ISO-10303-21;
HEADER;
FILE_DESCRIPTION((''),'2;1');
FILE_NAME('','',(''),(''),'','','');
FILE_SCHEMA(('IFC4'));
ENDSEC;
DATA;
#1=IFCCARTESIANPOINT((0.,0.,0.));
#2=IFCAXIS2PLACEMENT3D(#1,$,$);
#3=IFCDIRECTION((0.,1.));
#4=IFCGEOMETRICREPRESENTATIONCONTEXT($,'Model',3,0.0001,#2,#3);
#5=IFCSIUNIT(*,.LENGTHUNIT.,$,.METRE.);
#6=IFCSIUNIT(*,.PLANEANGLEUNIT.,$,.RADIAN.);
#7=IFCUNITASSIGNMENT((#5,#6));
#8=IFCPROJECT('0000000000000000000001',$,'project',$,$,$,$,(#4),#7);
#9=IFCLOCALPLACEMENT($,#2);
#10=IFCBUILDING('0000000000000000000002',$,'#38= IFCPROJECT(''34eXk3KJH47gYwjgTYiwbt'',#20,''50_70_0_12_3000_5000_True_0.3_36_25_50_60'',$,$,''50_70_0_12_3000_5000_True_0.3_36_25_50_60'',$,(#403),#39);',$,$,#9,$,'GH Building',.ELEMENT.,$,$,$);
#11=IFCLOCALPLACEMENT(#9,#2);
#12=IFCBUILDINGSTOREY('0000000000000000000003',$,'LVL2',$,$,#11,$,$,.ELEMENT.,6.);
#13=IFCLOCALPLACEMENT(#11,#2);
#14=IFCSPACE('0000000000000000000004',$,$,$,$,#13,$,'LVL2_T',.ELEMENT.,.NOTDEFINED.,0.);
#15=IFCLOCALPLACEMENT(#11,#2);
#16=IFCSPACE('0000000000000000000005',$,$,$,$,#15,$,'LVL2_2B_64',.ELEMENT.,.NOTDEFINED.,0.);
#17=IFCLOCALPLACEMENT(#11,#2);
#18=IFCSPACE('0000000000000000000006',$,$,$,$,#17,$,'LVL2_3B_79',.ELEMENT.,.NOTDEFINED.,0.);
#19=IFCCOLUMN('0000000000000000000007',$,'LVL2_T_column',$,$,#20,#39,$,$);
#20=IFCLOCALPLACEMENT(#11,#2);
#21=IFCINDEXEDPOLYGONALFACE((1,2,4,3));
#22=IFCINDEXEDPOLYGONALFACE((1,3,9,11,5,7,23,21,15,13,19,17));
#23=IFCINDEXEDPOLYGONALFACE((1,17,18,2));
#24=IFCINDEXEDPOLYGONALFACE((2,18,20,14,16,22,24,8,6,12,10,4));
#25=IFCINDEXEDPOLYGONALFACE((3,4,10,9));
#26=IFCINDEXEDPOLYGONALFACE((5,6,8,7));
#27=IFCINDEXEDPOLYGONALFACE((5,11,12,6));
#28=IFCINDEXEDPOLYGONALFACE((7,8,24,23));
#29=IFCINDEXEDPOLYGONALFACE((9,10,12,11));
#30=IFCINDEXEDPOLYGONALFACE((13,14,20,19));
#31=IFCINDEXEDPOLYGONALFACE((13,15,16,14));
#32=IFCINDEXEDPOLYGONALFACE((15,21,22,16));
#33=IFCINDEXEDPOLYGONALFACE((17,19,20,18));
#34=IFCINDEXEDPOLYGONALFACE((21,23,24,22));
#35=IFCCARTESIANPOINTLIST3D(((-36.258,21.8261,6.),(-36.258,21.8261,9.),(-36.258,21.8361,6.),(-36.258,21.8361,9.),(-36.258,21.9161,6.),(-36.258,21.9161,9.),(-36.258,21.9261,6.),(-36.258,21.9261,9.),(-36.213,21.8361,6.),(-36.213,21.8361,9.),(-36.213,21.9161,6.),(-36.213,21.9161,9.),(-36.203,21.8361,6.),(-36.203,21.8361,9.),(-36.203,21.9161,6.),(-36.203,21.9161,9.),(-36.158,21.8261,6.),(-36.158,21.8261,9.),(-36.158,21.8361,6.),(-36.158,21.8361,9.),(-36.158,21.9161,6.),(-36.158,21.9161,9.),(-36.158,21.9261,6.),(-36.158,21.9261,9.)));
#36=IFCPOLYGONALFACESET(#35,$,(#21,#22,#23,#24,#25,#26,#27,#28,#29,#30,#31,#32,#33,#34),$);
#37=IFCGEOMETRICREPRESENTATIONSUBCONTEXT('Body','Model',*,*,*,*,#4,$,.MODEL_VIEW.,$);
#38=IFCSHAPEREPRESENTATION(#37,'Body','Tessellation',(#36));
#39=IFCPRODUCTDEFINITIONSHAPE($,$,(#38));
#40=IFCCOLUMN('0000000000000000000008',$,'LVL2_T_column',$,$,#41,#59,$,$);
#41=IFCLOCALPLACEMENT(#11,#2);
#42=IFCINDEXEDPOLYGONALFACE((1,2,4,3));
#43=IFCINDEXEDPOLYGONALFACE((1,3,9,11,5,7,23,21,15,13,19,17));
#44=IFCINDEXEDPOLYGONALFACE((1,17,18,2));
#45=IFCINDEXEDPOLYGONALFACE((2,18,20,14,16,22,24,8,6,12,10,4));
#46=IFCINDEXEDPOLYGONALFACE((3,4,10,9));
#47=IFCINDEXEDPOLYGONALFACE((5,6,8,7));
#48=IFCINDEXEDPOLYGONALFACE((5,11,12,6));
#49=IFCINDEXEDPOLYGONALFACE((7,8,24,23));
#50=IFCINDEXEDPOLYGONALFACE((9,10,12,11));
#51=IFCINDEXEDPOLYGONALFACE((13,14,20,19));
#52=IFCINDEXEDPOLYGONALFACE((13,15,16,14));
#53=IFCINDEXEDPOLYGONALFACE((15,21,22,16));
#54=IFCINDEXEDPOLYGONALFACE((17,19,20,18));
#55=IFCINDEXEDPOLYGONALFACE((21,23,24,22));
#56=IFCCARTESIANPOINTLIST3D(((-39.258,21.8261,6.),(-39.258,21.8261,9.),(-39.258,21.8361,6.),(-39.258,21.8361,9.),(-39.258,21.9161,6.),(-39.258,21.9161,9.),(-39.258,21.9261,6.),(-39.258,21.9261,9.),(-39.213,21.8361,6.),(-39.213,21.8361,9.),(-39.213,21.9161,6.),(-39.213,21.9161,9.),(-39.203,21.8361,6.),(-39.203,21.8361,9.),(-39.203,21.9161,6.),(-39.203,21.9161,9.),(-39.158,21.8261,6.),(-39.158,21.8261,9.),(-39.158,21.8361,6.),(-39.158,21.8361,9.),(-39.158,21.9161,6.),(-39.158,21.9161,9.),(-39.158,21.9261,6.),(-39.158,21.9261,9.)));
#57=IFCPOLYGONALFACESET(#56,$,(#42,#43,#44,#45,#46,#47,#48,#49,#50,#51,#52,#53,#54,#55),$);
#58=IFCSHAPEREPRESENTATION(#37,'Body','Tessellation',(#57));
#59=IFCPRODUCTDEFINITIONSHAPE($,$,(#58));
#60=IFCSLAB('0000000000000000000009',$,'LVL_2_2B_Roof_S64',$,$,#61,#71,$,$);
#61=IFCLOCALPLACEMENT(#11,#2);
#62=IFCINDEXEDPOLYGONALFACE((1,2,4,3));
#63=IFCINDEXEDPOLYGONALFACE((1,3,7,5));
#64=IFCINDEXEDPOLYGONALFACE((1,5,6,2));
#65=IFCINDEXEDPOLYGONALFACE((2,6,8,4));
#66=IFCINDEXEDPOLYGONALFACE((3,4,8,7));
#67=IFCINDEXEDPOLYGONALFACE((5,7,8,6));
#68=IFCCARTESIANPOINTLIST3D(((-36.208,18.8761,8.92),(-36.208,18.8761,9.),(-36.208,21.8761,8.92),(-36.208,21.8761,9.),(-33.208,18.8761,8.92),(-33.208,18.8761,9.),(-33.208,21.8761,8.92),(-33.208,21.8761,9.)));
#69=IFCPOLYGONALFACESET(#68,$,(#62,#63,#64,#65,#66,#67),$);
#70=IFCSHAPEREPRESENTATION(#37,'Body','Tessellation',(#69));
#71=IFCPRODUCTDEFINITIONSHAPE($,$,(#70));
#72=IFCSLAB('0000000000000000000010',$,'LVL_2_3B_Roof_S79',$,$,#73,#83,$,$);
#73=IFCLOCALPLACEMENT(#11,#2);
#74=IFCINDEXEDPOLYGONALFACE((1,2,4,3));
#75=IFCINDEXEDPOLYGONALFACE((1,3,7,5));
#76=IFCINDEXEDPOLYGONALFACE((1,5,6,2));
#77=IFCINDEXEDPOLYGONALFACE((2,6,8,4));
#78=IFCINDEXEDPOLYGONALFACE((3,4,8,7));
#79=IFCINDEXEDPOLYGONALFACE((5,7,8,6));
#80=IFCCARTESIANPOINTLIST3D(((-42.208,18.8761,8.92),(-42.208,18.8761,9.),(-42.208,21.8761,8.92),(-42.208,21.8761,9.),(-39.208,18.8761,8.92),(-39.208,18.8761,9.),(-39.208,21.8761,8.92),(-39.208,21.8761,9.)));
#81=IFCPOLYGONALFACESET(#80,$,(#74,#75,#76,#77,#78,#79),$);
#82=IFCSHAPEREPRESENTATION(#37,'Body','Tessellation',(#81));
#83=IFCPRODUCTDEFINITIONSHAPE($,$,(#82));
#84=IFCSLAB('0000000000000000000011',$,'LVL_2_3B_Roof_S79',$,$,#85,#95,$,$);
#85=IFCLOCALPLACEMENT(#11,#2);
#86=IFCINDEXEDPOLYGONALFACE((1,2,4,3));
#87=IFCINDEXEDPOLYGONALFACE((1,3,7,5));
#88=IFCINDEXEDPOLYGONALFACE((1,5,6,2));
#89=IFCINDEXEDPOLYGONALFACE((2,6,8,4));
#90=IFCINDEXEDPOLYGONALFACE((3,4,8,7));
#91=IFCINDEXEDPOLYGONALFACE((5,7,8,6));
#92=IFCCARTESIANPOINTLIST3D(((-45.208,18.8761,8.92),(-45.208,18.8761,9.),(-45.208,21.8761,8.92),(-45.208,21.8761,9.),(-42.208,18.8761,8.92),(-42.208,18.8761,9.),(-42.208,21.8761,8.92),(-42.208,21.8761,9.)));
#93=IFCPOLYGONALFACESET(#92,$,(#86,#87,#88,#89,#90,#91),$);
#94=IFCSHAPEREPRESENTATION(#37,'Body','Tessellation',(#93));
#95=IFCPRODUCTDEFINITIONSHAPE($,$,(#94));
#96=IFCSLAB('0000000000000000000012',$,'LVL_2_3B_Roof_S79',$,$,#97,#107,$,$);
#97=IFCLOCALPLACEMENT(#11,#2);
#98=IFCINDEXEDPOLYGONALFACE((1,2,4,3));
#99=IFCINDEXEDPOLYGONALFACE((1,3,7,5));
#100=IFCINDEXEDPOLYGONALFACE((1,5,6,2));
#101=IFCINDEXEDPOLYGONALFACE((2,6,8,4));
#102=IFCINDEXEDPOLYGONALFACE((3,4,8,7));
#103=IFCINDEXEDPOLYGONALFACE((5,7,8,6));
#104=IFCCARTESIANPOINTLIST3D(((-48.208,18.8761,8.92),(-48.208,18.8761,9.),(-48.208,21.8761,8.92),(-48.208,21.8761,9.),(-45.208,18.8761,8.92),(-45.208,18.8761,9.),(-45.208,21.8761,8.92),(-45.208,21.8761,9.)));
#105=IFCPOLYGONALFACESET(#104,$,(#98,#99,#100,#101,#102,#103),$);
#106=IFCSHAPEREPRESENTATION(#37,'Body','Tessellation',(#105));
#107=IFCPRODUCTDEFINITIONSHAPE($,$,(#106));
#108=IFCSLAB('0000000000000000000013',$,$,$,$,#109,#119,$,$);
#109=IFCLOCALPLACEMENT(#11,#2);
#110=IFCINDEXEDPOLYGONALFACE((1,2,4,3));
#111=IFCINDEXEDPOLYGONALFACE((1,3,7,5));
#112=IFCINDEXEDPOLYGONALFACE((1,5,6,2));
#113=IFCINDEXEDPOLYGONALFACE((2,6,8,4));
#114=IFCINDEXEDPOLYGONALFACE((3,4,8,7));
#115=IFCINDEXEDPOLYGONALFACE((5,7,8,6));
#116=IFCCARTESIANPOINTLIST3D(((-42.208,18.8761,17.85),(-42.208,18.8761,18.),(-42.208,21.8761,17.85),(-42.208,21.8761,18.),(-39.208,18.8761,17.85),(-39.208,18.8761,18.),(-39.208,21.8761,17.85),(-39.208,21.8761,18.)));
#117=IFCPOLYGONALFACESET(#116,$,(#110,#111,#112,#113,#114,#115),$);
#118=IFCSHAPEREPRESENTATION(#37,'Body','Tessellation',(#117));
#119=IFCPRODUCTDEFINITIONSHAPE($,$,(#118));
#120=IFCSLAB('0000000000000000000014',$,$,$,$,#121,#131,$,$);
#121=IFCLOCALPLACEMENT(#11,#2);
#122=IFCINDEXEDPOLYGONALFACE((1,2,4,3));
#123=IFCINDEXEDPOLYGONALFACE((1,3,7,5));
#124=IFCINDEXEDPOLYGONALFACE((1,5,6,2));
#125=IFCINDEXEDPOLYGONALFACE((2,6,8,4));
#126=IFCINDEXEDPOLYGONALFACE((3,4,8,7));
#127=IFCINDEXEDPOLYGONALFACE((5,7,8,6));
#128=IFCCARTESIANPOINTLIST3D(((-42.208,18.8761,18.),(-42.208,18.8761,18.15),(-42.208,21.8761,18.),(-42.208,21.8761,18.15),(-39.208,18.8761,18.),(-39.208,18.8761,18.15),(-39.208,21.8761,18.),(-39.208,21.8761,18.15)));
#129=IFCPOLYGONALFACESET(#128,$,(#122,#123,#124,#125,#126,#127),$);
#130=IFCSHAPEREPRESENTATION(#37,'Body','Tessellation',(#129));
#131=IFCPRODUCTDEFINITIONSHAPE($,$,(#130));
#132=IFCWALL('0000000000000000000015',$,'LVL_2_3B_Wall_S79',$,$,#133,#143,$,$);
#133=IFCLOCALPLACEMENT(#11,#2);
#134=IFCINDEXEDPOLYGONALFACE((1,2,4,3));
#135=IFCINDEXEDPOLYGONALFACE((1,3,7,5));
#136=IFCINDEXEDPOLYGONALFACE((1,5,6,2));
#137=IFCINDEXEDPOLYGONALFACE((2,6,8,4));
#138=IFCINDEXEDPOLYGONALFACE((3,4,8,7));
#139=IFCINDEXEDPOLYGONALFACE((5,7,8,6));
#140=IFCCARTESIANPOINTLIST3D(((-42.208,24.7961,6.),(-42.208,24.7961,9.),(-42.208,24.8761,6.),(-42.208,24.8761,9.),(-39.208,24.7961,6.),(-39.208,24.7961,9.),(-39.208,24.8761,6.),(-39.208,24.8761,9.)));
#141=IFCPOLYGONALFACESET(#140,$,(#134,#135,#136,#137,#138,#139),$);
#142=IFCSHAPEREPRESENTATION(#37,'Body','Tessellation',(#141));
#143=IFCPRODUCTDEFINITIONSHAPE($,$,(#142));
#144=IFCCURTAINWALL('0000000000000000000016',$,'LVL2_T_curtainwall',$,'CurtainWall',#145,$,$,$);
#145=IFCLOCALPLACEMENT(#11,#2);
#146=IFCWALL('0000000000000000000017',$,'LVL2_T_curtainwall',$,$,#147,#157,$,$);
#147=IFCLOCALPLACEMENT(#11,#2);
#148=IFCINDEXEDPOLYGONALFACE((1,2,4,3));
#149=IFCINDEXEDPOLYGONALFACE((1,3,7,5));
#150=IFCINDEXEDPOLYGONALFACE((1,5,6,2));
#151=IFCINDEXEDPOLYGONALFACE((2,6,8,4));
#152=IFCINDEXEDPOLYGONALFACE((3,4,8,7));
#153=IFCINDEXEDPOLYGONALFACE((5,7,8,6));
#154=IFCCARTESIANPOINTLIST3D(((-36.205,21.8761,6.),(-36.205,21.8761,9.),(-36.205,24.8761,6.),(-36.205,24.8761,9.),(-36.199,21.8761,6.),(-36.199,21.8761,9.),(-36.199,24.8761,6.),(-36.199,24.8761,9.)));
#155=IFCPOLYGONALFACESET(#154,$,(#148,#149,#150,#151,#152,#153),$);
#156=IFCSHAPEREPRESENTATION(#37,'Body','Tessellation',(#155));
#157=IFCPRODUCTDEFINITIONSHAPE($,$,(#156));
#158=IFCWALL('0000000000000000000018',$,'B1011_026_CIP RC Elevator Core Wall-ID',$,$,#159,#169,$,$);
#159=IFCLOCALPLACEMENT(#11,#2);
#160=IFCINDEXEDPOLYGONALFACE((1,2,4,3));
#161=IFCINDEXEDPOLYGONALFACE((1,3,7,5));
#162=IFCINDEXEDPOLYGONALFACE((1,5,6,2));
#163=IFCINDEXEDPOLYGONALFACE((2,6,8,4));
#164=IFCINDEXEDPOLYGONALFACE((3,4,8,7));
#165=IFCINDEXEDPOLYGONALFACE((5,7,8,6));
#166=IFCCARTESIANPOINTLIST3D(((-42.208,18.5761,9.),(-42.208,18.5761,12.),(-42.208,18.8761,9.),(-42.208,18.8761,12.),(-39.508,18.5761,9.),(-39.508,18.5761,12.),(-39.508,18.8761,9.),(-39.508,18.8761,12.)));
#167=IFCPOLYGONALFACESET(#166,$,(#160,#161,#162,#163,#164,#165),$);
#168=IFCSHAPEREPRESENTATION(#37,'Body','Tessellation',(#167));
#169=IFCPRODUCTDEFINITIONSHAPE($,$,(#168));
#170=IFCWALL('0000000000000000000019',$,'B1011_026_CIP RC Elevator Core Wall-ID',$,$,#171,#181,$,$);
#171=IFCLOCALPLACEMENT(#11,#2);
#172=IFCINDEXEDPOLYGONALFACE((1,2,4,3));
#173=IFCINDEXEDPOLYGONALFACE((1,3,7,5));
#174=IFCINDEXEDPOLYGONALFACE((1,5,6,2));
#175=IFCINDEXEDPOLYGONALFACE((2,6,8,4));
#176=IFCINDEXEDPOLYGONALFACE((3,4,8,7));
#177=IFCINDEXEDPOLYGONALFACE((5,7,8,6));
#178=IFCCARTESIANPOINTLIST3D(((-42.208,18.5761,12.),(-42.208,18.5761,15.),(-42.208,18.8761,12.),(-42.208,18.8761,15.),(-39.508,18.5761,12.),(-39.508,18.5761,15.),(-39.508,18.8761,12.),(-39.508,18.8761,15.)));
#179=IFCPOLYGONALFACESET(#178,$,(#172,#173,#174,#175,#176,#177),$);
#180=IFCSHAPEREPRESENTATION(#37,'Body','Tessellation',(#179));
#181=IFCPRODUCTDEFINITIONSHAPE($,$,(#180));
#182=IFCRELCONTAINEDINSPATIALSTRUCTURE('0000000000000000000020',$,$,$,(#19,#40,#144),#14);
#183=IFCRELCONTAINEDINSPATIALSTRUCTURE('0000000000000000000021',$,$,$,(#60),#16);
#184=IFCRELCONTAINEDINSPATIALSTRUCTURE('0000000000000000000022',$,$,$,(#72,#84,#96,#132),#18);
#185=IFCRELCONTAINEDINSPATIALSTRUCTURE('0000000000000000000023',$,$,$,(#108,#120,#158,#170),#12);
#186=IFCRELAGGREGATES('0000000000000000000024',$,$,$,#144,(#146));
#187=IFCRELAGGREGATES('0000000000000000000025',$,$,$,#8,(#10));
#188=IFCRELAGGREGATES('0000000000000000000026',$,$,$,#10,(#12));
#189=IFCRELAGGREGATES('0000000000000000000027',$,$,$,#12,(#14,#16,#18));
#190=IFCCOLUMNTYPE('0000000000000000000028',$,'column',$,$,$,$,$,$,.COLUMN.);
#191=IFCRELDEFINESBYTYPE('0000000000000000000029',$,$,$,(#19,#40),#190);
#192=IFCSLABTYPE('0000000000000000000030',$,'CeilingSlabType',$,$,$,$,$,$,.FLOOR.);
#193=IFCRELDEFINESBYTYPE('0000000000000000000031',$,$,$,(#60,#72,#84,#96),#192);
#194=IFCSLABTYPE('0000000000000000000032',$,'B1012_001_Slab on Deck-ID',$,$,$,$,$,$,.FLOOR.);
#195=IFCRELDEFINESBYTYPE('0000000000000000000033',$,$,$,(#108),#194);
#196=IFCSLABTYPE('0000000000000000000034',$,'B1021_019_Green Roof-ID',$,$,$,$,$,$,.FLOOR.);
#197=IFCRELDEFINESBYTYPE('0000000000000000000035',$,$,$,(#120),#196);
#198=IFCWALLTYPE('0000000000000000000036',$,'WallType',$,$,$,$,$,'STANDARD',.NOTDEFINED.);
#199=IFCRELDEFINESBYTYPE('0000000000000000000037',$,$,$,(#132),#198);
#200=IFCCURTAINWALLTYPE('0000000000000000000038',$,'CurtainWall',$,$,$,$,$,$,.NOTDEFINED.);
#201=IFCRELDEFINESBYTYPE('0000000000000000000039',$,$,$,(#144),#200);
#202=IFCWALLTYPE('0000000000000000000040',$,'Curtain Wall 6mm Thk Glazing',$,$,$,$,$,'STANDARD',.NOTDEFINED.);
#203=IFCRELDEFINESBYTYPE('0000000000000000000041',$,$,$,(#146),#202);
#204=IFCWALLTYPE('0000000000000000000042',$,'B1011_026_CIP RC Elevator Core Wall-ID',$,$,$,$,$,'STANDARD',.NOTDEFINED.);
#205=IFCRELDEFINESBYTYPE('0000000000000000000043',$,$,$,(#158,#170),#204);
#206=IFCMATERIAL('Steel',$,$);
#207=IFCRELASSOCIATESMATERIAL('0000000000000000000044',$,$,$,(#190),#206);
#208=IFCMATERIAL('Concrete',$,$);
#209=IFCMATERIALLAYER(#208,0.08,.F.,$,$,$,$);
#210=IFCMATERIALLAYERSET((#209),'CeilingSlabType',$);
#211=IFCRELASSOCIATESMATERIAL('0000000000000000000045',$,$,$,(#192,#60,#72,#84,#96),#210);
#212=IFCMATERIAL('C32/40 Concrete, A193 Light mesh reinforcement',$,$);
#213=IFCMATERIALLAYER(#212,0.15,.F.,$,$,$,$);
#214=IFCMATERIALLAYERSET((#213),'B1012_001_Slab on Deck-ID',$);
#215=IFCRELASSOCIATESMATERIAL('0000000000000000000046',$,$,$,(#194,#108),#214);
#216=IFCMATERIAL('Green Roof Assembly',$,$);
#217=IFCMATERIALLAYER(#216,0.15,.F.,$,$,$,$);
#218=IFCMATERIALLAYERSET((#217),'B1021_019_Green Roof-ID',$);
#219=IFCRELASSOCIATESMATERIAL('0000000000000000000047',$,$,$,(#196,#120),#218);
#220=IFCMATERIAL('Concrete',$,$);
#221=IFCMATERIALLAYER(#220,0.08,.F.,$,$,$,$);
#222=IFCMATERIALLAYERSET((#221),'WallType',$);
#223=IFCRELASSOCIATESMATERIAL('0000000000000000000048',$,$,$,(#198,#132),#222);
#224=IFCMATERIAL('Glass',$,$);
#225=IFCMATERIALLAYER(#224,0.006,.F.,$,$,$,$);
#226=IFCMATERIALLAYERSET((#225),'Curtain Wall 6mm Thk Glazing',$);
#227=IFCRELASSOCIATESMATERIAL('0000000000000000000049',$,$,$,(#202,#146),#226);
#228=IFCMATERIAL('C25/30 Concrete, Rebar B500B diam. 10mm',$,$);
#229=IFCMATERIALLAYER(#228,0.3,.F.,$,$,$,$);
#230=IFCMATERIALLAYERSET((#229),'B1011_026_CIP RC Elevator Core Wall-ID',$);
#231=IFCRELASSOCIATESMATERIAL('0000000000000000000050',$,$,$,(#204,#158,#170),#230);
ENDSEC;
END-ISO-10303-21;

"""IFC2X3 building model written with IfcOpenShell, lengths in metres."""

from ifc_helpers import new_model, si_unit, direction, frame, frame_2d, origin, origin_2d, place, context, subcontext, project, spatial, polyline, rectangle, i_section, outline, extrude, material, layer, layer_set, layer_usage, type_object, element, aggregate, save


model = new_model("IFC2X3")

# Units and contexts
model_context = context("Model", 3, precision=0.0001, world=origin(), true_north=direction((0.0, 1.0)))
body_context = subcontext(model_context, "Body", "Model", "MODEL_VIEW")
ifc_project = project(units=[si_unit("LENGTHUNIT", "METRE"), si_unit("PLANEANGLEUNIT", "RADIAN")], contexts=[model_context])

# Building, storey, space
building_placement = place(None, origin())
building = spatial("IfcBuilding", under=ifc_project, at=building_placement, Name="#38= IFCPROJECT('34eXk3KJH47gYwjgTYiwbt',#20,'50_70_0_12_3000_5000_True_0.3_36_25_50_60',$,$,'50_70_0_12_3000_5000_True_0.3_36_25_50_60',$,(#403),#39);", LongName="GH Building", CompositionType="ELEMENT")
storey_placement = place(building_placement, origin())
storey = spatial("IfcBuildingStorey", under=building, at=storey_placement, Name="LVL2", CompositionType="ELEMENT", Elevation=6.0)
space_1_placement = place(storey_placement, origin())
space_1 = spatial("IfcSpace", under=storey, at=space_1_placement, LongName="LVL2_T", CompositionType="ELEMENT", InteriorOrExteriorSpace="NOTDEFINED", ElevationWithFlooring=0.0)

# Columns
ifc_material_1 = material(Name="Steel")
column_type = type_object("IfcColumnType", Name="column", PredefinedType="COLUMN", material=ifc_material_1)
for number, where, name in (
    (1, (-36.208, 21.8761, 6.0), "LVL2_T_column"),
    (2, (-39.208, 21.8761, 6.0), "LVL2_T_column"),
):
    element("IfcColumn", number, at=place(space_1_placement, frame(where)), inside=space_1, type_object=column_type, Name=name, context=body_context, shape_type="SweptSolid", body=[
        extrude(i_section(OverallWidth=0.1, OverallDepth=0.1, WebThickness=0.01, FlangeThickness=0.01, at=origin_2d()), origin(), (0.0, 0.0, 1.0), 3.0),
    ])

# Shared definitions
space_2_placement = place(storey_placement, origin())
space_2 = spatial("IfcSpace", under=storey, at=space_2_placement, LongName="LVL2_2B_64", CompositionType="ELEMENT", InteriorOrExteriorSpace="NOTDEFINED", ElevationWithFlooring=0.0)

# Slab
ifc_material_2 = material(Name="Concrete")
ifc_layer_1 = layer(ifc_material_2, 0.08, ventilated=False)
ifc_layer_set_1 = layer_set([ifc_layer_1], Name="CeilingSlabType")
ifc_layer_usage_1 = layer_usage(ifc_layer_set_1, "AXIS3", "NEGATIVE", -0.08)
slab_type_1 = type_object("IfcSlabType", Name="CeilingSlabType", PredefinedType="FLOOR", material=ifc_layer_set_1)
slab_1_placement = place(space_2_placement, frame((-33.208, 21.8761, 8.92), z_axis=(0.0, 0.0, 1.0), x_axis=(-1.0, 0.0, 0.0)))
element("IfcSlab", 3, at=slab_1_placement, inside=space_2, type_object=slab_type_1, material=ifc_layer_usage_1, Name="LVL_2_2B_Roof_S64", context=body_context, shape_type="SweptSolid", body=[
    extrude(rectangle(XDim=3.0, YDim=3.0, at=frame_2d((1.5, 1.5))), origin(), (0.0, 0.0, 1.0), 0.08),
])

# Shared definitions
space_3_placement = place(storey_placement, origin())
space_3 = spatial("IfcSpace", under=storey, at=space_3_placement, LongName="LVL2_3B_79", CompositionType="ELEMENT", InteriorOrExteriorSpace="NOTDEFINED", ElevationWithFlooring=0.0)

# Slabs
ifc_layer_usage_2 = layer_usage(ifc_layer_set_1, "AXIS3", "NEGATIVE", -0.08)
slab_2_placement = place(space_3_placement, frame((-39.208, 21.8761, 8.92), z_axis=(0.0, 0.0, 1.0), x_axis=(-1.0, 0.0, 0.0)))
element("IfcSlab", 4, at=slab_2_placement, inside=space_3, type_object=slab_type_1, material=ifc_layer_usage_2, Name="LVL_2_3B_Roof_S79", context=body_context, shape_type="SweptSolid", body=[
    extrude(rectangle(XDim=3.0, YDim=3.0, at=frame_2d((1.5, 1.5))), origin(), (0.0, 0.0, 1.0), 0.08),
])
ifc_layer_usage_3 = layer_usage(ifc_layer_set_1, "AXIS3", "NEGATIVE", -0.08)
slab_3_placement = place(space_3_placement, frame((-42.208, 21.8761, 8.92), z_axis=(0.0, 0.0, 1.0), x_axis=(-1.0, 0.0, 0.0)))
element("IfcSlab", 5, at=slab_3_placement, inside=space_3, type_object=slab_type_1, material=ifc_layer_usage_3, Name="LVL_2_3B_Roof_S79", context=body_context, shape_type="SweptSolid", body=[
    extrude(rectangle(XDim=3.0, YDim=3.0, at=frame_2d((1.5, 1.5))), origin(), (0.0, 0.0, 1.0), 0.08),
])
ifc_layer_usage_4 = layer_usage(ifc_layer_set_1, "AXIS3", "NEGATIVE", -0.08)
slab_4_placement = place(space_3_placement, frame((-48.208, 21.8761, 8.92)))
element("IfcSlab", 6, at=slab_4_placement, inside=space_3, type_object=slab_type_1, material=ifc_layer_usage_4, Name="LVL_2_3B_Roof_S79", context=body_context, shape_type="SweptSolid", body=[
    extrude(rectangle(XDim=3.0, YDim=3.0, at=frame_2d((1.5, -1.5))), origin(), (0.0, 0.0, 1.0), 0.08),
])
ifc_material_3 = material(Name="C32/40 Concrete, A193 Light mesh reinforcement")
ifc_layer_2 = layer(ifc_material_3, 0.15, ventilated=False)
ifc_layer_set_2 = layer_set([ifc_layer_2], Name="B1012_001_Slab on Deck-ID")
ifc_layer_usage_5 = layer_usage(ifc_layer_set_2, "AXIS3", "NEGATIVE", -0.15)
slab_type_2 = type_object("IfcSlabType", Name="B1012_001_Slab on Deck-ID", PredefinedType="FLOOR", material=ifc_layer_set_2)
slab_5_placement = place(storey_placement, frame((-40.708, 20.3761, 17.85)))
element("IfcSlab", 7, at=slab_5_placement, inside=storey, type_object=slab_type_2, material=ifc_layer_usage_5, context=body_context, shape_type="SweptSolid", body=[
    extrude(outline(polyline([(-1.5, -1.5), (-1.5, 1.5), (1.5, 1.5), (1.5, -1.5), (-1.5, -1.5)])), origin(), (0.0, 0.0, 1.0), 0.15),
])
ifc_material_4 = material(Name="Green Roof Assembly")
ifc_layer_3 = layer(ifc_material_4, 0.15, ventilated=False)
ifc_layer_set_3 = layer_set([ifc_layer_3], Name="B1021_019_Green Roof-ID")
ifc_layer_usage_6 = layer_usage(ifc_layer_set_3, "AXIS3", "NEGATIVE", -0.15)
slab_type_3 = type_object("IfcSlabType", Name="B1021_019_Green Roof-ID", PredefinedType="FLOOR", material=ifc_layer_set_3)
slab_6_placement = place(storey_placement, frame((-40.708, 20.3761, 18.0)))
element("IfcSlab", 8, at=slab_6_placement, inside=storey, type_object=slab_type_3, material=ifc_layer_usage_6, context=body_context, shape_type="SweptSolid", body=[
    extrude(outline(polyline([(-1.5, -1.5), (-1.5, 1.5), (1.5, 1.5), (1.5, -1.5), (-1.5, -1.5)])), origin(), (0.0, 0.0, 1.0), 0.15),
])

# Shared definitions
ifc_material_5 = material(Name="Concrete")
ifc_layer_4 = layer(ifc_material_5, 0.08, ventilated=False)
ifc_layer_set_4 = layer_set([ifc_layer_4], Name="WallType")
wall_type_1 = type_object("IfcWallType", Name="WallType", ElementType="STANDARD", PredefinedType="NOTDEFINED", material=ifc_layer_set_4)

# Wall
ifc_layer_usage_7 = layer_usage(ifc_layer_set_4, "AXIS2", "NEGATIVE", 0.0)
wall_1_placement = place(space_3_placement, frame((-42.208, 24.8761, 6.0)))
element("IfcWall", 9, at=wall_1_placement, inside=space_3, type_object=wall_type_1, material=ifc_layer_usage_7, Name="LVL_2_3B_Wall_S79", context=body_context, shape_type="SweptSolid", body=[
    extrude(rectangle(XDim=3.0, YDim=0.08, at=frame_2d((1.5, -0.04))), origin(), (0.0, 0.0, 1.0), 3.0),
])

# Curtain wall, wall
curtain_wall_type = type_object("IfcCurtainWallType", Name="CurtainWall", PredefinedType="NOTDEFINED")
curtain_wall_placement = place(None, origin())
curtain_wall = element("IfcCurtainWall", 10, at=curtain_wall_placement, inside=space_1, type_object=curtain_wall_type, Name="LVL2_T_curtainwall", ObjectType="CurtainWall")
ifc_material_6 = material(Name="Glass")
ifc_layer_5 = layer(ifc_material_6, 0.006, ventilated=False)
ifc_layer_set_5 = layer_set([ifc_layer_5], Name="Curtain Wall 6mm Thk Glazing")
ifc_layer_usage_8 = layer_usage(ifc_layer_set_5, "AXIS2", "NEGATIVE", -0.003)
wall_type_2 = type_object("IfcWallType", Name="Curtain Wall 6mm Thk Glazing", ElementType="STANDARD", PredefinedType="NOTDEFINED", material=ifc_layer_set_5)
wall_2_placement = place(curtain_wall_placement, frame((-36.208, 21.8761, 6.0), z_axis=(0.0, 0.0, 1.0), x_axis=(0.0, 1.0, 0.0)))
wall_2 = element("IfcWall", 11, at=wall_2_placement, type_object=wall_type_2, material=ifc_layer_usage_8, Name="LVL2_T_curtainwall", context=body_context, shape_type="SweptSolid", body=[
    extrude(rectangle(XDim=3.0, YDim=0.006, at=frame_2d((1.5, -0.006))), origin(), (0.0, 0.0, 1.0), 3.0),
])
aggregate(curtain_wall, [wall_2])

# Walls
ifc_material_7 = material(Name="C25/30 Concrete, Rebar B500B diam. 10mm")
ifc_layer_6 = layer(ifc_material_7, 0.3, ventilated=False)
ifc_layer_set_6 = layer_set([ifc_layer_6], Name="B1011_026_CIP RC Elevator Core Wall-ID")
ifc_layer_usage_9 = layer_usage(ifc_layer_set_6, "AXIS2", "POSITIVE", 0.0)
wall_type_3 = type_object("IfcWallType", Name="B1011_026_CIP RC Elevator Core Wall-ID", ElementType="STANDARD", PredefinedType="NOTDEFINED", material=ifc_layer_set_6)
wall_3_placement = place(storey_placement, frame((-39.508, 18.8761, 9.0), z_axis=(0.0, 0.0, 1.0), x_axis=(-1.0, 0.0, 0.0)))
element("IfcWall", 12, at=wall_3_placement, inside=storey, type_object=wall_type_3, material=ifc_layer_usage_9, Name="B1011_026_CIP RC Elevator Core Wall-ID", context=body_context, shape_type="SweptSolid", body=[
    extrude(rectangle(XDim=2.7, YDim=0.3, at=frame_2d((1.35, 0.15))), origin(), (0.0, 0.0, 1.0), 3.0),
])
ifc_layer_usage_10 = layer_usage(ifc_layer_set_6, "AXIS2", "POSITIVE", 0.0)
wall_4_placement = place(storey_placement, frame((-39.508, 18.8761, 12.0), z_axis=(0.0, 0.0, 1.0), x_axis=(-1.0, 0.0, 0.0)))
element("IfcWall", 13, at=wall_4_placement, inside=storey, type_object=wall_type_3, material=ifc_layer_usage_10, Name="B1011_026_CIP RC Elevator Core Wall-ID", context=body_context, shape_type="SweptSolid", body=[
    extrude(rectangle(XDim=2.7, YDim=0.3, at=frame_2d((1.35, 0.15))), origin(), (0.0, 0.0, 1.0), 3.0),
])

save(model, "model.ifc")
